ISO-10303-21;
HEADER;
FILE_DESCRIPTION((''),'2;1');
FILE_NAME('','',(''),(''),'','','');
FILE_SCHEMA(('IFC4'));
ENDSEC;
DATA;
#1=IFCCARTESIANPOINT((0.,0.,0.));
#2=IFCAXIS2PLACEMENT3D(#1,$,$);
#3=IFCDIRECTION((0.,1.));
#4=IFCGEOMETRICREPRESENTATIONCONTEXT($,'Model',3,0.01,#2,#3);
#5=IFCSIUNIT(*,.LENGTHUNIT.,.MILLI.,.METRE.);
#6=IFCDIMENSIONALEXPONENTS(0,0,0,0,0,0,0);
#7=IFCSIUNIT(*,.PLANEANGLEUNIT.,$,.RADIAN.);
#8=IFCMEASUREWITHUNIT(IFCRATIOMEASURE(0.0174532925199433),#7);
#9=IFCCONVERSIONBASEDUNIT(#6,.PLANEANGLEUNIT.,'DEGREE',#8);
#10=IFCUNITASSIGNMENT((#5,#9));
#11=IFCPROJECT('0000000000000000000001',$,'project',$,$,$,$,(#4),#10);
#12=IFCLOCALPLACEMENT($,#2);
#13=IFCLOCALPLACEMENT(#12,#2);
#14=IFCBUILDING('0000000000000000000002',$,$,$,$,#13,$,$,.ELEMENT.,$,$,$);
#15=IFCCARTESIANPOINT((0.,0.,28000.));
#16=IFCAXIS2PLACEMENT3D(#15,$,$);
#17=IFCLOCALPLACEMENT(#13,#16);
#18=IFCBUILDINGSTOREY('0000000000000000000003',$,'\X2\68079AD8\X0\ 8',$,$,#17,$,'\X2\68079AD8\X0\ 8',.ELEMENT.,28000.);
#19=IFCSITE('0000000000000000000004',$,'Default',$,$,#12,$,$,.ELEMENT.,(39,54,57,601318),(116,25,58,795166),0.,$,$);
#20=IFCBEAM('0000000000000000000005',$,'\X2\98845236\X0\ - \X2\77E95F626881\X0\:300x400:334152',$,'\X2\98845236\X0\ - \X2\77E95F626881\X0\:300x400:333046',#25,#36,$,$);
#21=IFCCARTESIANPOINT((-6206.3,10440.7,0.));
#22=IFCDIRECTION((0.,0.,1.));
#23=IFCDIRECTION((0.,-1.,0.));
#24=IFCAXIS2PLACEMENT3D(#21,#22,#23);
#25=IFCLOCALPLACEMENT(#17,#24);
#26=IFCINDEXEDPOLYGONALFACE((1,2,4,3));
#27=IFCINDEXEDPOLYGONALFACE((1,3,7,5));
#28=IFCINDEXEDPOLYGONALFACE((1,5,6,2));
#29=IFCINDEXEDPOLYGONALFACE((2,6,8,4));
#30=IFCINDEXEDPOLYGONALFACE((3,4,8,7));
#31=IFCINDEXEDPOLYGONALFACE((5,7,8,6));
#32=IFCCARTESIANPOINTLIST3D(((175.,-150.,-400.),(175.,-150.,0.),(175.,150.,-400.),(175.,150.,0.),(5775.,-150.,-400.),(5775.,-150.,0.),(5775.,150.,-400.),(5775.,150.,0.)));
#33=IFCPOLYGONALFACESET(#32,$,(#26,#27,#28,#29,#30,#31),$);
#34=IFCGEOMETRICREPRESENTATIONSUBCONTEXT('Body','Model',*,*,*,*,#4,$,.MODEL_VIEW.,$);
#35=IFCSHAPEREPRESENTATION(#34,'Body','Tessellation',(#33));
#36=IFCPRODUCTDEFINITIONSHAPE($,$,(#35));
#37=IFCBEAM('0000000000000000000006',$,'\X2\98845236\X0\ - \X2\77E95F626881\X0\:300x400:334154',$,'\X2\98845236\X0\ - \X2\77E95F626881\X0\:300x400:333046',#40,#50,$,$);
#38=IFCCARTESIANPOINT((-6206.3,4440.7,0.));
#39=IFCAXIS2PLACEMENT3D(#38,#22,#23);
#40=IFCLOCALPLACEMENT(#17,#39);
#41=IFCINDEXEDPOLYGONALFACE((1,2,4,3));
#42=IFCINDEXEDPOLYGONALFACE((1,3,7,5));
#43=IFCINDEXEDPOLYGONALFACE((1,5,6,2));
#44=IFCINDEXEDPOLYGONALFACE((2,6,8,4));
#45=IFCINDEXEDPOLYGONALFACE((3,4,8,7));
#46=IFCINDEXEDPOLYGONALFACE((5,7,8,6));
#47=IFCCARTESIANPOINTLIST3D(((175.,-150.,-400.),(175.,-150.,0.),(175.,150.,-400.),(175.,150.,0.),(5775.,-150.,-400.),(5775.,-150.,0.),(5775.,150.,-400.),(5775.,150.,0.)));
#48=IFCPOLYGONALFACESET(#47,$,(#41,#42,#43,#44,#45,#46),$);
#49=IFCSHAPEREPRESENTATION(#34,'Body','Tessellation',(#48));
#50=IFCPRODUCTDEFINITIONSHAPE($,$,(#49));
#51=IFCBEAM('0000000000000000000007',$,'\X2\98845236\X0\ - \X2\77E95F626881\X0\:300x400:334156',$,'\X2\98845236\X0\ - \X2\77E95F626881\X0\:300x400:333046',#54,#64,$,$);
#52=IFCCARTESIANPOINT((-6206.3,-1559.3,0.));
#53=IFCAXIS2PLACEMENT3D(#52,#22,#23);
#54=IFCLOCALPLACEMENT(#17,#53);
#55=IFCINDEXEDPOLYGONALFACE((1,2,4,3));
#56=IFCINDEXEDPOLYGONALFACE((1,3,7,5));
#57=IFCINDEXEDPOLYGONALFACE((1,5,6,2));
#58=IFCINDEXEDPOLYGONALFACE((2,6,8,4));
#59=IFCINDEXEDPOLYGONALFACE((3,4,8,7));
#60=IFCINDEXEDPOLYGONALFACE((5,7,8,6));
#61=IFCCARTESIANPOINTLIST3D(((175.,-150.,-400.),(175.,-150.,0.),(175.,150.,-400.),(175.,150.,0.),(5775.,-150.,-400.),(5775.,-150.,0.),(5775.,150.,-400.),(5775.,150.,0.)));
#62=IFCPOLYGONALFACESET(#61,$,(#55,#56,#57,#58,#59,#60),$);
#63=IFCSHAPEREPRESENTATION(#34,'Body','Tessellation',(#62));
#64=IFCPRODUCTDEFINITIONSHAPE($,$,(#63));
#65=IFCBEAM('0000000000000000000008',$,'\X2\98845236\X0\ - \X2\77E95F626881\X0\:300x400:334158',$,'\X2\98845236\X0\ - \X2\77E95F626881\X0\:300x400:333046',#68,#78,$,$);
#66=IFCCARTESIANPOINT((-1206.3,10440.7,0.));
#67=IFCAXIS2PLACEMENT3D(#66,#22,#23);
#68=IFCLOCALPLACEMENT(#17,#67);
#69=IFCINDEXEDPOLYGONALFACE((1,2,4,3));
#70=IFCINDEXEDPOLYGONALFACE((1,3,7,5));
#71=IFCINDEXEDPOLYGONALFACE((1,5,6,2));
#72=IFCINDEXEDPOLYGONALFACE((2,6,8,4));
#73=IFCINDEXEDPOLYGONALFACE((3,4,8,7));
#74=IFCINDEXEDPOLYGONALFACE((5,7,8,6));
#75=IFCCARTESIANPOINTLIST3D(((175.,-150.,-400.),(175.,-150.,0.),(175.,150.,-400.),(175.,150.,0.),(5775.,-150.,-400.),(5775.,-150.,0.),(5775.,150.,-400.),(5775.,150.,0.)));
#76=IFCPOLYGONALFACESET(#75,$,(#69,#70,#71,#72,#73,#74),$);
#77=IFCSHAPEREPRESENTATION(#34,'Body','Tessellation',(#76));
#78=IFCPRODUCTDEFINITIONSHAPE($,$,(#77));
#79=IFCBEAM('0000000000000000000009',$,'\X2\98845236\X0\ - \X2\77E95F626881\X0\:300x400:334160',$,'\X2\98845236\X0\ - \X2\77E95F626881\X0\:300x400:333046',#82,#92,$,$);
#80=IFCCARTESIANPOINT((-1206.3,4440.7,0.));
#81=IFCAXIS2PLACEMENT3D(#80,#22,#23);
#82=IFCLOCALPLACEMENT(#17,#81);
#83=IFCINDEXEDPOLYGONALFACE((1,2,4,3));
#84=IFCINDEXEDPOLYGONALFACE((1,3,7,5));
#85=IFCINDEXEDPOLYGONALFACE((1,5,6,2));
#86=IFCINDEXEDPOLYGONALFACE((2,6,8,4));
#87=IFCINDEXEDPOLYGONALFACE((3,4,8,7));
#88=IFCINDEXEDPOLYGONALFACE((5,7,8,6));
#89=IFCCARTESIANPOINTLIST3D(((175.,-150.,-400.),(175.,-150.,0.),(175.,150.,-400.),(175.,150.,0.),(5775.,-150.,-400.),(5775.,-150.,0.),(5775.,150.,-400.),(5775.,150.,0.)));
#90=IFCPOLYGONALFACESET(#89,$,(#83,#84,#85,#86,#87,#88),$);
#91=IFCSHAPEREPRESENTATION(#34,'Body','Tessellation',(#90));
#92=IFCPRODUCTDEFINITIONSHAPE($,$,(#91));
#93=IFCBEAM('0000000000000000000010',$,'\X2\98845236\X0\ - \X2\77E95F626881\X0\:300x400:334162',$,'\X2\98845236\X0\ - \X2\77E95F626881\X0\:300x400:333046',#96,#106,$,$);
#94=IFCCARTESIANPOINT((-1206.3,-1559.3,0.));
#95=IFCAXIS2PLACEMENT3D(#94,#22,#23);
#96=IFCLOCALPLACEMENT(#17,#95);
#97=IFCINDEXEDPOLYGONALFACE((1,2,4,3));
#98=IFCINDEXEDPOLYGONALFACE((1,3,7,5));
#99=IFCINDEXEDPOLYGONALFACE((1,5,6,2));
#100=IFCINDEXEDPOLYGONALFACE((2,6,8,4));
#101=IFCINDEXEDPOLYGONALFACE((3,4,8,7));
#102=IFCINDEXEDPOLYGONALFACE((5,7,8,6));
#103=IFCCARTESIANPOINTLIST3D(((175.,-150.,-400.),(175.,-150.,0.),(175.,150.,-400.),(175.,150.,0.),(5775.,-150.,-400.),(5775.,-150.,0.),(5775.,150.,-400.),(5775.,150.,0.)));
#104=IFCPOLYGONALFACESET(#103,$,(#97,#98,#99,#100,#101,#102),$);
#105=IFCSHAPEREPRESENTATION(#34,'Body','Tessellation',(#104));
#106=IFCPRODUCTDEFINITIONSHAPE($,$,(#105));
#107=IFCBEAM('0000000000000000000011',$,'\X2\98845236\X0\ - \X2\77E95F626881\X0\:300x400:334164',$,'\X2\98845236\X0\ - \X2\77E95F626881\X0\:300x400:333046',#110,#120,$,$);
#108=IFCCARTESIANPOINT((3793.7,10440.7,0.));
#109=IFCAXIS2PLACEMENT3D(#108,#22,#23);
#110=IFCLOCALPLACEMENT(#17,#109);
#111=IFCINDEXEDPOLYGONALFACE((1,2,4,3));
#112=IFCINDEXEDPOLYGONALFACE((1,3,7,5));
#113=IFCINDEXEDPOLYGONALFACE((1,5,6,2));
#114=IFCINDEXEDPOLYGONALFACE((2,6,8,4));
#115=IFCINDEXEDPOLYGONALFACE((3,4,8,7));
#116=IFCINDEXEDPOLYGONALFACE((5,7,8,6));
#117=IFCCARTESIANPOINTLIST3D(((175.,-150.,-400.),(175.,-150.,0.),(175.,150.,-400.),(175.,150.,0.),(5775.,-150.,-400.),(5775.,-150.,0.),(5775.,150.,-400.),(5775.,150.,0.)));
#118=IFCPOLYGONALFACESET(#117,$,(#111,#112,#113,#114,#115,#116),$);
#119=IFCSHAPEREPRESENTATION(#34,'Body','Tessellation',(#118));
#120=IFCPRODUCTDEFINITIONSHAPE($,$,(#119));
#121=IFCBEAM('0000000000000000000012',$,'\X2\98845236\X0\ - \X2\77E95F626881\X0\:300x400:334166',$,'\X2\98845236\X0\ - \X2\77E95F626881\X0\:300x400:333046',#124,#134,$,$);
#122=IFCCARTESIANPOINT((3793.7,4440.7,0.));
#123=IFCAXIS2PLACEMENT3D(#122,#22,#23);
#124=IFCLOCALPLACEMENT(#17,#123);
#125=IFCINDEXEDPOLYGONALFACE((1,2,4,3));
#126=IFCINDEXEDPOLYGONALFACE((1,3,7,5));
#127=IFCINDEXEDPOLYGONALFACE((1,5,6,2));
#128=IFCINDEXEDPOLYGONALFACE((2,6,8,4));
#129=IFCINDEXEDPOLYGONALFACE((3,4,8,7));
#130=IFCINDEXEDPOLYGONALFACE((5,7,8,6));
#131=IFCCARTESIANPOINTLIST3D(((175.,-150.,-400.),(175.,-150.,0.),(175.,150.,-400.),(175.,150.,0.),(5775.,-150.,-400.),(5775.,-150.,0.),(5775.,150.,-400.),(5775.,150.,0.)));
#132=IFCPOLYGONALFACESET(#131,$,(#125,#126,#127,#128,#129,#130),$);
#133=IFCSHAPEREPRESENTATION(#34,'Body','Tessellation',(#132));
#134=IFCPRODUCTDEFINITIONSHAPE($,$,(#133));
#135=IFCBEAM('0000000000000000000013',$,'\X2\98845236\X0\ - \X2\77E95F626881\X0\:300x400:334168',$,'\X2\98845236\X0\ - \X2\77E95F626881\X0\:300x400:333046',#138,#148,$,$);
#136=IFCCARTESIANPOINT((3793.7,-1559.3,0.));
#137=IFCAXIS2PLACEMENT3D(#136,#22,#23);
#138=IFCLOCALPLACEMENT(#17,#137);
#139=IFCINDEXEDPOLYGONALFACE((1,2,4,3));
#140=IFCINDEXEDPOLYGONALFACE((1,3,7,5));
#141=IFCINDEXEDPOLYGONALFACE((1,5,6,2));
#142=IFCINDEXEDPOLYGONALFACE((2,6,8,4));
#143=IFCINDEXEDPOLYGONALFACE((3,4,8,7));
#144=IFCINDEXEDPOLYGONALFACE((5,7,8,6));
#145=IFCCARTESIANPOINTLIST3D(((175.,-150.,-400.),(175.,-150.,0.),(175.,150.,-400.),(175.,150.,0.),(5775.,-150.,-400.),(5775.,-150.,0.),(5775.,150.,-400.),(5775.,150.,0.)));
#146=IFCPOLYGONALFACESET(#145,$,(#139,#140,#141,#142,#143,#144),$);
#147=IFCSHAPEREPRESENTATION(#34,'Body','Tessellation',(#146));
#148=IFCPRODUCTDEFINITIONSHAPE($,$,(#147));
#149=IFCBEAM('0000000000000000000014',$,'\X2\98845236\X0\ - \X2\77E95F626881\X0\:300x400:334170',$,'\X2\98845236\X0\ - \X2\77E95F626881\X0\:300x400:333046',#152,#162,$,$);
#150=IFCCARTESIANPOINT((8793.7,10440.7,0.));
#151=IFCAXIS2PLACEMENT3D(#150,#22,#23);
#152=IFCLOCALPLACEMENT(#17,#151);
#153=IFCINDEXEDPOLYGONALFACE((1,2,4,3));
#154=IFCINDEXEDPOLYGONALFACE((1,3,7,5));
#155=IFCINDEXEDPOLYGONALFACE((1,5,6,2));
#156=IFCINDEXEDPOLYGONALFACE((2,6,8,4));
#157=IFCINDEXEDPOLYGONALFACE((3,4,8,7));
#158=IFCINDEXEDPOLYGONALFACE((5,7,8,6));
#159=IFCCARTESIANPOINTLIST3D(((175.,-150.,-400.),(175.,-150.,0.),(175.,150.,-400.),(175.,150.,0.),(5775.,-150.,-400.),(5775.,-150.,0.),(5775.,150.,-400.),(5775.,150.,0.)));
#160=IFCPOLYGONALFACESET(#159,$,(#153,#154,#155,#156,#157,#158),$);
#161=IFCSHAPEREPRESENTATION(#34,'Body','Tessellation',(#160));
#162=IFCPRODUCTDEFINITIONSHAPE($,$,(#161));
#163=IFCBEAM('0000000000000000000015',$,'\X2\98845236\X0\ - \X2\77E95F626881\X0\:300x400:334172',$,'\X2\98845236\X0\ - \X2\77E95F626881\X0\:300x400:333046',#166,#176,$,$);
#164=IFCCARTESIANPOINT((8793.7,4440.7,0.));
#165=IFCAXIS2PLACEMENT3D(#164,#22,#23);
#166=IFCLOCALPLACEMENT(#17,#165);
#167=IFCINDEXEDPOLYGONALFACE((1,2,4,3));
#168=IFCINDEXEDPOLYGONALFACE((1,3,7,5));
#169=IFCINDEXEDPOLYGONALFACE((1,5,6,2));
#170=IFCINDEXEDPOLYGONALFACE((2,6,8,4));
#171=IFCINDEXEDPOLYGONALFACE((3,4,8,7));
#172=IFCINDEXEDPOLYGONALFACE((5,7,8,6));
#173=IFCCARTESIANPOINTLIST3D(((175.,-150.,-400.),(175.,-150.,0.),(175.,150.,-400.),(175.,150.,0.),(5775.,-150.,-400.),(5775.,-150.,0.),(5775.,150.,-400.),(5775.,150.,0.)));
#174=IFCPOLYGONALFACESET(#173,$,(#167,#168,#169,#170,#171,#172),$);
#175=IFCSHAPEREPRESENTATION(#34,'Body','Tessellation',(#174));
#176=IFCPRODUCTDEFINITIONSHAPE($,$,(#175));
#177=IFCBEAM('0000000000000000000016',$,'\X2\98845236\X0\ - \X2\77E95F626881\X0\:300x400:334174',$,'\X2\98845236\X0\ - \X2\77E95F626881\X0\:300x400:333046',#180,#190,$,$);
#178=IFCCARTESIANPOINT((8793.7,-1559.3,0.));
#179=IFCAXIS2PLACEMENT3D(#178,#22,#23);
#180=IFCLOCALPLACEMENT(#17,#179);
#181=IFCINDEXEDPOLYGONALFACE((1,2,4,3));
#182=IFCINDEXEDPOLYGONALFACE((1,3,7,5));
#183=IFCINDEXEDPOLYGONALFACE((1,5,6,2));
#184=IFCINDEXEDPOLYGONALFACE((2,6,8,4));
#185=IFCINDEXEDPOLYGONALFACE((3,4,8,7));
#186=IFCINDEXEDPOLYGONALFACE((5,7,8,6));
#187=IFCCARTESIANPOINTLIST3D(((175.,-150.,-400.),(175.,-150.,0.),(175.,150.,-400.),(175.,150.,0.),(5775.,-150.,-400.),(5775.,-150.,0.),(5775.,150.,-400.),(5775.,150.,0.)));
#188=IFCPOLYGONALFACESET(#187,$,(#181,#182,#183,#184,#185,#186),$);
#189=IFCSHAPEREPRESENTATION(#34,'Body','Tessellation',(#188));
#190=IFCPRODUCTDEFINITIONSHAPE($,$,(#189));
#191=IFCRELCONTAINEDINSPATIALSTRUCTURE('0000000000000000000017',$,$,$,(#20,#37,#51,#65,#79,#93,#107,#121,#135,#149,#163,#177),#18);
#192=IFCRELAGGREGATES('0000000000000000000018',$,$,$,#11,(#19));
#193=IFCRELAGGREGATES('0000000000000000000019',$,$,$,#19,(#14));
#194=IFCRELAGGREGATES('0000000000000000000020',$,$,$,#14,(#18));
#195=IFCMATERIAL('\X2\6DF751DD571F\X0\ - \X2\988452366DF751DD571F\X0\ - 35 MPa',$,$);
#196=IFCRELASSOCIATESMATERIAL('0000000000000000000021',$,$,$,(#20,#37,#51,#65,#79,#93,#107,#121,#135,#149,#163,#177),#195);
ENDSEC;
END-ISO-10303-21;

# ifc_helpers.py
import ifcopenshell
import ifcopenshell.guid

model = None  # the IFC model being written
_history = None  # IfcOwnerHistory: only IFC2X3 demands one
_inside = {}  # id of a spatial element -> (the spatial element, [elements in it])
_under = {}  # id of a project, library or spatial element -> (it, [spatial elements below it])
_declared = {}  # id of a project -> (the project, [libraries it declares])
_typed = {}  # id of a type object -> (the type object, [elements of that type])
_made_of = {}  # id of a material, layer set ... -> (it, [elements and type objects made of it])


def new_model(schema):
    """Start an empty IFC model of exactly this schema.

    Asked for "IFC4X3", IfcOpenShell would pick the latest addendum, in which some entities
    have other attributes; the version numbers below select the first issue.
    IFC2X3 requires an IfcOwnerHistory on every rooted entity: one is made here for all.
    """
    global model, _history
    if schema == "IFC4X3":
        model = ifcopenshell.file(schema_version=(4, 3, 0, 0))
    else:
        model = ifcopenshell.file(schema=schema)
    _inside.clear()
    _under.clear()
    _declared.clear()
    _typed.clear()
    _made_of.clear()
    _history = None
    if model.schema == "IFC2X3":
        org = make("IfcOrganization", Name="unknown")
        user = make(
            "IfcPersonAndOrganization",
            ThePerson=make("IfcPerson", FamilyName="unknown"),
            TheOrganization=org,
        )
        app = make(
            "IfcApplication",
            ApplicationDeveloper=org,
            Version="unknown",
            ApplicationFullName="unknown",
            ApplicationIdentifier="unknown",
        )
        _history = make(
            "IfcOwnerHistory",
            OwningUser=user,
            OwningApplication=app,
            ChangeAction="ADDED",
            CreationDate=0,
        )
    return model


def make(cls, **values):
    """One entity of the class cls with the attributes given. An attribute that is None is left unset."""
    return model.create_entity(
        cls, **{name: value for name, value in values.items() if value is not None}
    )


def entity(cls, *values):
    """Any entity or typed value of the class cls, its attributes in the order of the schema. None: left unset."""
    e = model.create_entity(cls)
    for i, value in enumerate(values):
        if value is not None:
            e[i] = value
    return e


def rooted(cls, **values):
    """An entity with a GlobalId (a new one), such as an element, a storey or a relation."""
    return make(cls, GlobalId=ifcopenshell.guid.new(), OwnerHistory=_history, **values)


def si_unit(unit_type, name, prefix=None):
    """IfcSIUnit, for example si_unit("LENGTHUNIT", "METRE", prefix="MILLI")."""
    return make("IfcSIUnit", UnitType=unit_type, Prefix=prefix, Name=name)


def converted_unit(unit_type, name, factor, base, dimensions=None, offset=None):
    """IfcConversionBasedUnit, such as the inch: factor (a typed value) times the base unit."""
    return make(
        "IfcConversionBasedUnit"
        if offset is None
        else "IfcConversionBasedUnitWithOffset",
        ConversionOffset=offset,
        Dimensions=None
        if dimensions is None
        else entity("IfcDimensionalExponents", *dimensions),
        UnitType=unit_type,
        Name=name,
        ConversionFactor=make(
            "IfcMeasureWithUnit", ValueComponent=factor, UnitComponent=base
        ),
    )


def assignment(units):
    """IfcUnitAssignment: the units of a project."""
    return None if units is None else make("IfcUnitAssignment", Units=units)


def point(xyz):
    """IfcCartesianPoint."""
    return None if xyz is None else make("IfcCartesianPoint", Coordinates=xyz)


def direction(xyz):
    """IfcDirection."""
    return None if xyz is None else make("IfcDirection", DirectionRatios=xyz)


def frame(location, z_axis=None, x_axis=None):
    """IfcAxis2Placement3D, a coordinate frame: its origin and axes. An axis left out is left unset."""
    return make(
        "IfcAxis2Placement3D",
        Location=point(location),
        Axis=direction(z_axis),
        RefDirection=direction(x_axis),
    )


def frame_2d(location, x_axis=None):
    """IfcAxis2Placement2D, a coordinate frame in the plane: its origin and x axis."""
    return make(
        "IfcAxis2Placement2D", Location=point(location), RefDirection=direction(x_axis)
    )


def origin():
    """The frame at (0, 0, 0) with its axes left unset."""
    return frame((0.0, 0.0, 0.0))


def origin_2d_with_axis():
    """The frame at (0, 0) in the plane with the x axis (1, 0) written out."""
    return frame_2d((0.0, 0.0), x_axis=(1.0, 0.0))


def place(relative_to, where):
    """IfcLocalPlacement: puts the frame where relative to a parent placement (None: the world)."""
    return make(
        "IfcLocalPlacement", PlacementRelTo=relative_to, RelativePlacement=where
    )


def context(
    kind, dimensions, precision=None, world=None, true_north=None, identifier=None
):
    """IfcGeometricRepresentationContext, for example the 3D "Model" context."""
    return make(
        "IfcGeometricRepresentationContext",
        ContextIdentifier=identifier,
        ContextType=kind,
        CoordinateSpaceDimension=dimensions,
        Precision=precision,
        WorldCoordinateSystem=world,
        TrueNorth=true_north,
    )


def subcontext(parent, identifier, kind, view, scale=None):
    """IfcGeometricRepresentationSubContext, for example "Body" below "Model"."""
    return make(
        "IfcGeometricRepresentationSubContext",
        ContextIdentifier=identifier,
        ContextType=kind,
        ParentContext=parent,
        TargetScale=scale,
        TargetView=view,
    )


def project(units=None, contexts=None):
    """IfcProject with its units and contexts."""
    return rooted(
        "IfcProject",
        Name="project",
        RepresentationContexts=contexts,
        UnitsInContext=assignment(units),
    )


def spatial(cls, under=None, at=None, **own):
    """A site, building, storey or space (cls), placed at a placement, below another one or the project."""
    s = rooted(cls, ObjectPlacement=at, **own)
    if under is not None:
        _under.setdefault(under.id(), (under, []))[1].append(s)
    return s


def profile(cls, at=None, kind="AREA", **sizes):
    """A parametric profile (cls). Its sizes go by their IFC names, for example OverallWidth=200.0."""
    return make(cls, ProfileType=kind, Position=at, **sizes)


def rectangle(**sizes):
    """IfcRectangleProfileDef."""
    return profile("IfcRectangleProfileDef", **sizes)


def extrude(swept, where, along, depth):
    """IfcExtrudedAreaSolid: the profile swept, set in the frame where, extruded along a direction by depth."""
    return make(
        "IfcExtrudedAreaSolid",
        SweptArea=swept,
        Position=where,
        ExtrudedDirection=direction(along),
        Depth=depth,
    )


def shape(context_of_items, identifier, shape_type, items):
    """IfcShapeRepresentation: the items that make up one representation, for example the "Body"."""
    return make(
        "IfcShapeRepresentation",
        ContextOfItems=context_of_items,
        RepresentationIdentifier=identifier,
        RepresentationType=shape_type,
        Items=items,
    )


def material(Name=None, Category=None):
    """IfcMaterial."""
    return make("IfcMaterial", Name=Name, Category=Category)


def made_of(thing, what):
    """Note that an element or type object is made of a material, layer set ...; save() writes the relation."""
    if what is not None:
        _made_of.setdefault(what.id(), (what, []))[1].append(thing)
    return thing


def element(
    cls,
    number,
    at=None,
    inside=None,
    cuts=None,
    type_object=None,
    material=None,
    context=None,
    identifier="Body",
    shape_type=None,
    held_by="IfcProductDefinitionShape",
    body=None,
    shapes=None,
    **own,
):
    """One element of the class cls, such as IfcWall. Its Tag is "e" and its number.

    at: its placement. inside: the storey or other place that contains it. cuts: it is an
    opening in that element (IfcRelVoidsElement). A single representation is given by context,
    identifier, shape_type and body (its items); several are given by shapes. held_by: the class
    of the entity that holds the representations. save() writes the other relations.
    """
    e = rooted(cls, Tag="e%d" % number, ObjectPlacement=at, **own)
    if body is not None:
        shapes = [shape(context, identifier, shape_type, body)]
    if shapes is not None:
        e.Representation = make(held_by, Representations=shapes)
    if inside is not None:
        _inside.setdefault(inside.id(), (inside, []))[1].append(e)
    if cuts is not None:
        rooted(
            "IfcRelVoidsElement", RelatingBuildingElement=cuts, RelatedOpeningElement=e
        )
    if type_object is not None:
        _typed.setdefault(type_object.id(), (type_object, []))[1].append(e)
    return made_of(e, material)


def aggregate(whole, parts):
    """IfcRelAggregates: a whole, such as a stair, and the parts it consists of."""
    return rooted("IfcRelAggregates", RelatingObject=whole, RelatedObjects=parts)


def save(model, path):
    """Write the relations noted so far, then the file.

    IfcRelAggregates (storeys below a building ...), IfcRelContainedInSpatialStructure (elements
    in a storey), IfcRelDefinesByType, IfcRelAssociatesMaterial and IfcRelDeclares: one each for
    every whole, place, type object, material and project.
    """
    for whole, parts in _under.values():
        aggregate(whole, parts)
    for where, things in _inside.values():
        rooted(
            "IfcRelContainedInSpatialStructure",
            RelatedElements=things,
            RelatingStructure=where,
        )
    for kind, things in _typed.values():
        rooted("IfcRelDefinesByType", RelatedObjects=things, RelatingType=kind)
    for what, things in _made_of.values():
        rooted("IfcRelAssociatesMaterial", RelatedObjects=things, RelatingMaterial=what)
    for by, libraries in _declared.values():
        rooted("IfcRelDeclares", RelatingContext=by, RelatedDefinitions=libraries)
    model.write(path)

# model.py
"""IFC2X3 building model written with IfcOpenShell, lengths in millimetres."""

from ifc_helpers import new_model, entity, si_unit, converted_unit, direction, frame, frame_2d, origin, origin_2d_with_axis, place, context, subcontext, project, spatial, rectangle, extrude, material, element, save


model = new_model("IFC2X3")

# Units and contexts
model_context = context("Model", 3, precision=0.01, world=origin(), true_north=direction((0.0, 1.0)))
body_context = subcontext(model_context, "Body", "Model", "MODEL_VIEW")
ifc_project = project(units=[si_unit("LENGTHUNIT", "METRE", prefix="MILLI"), converted_unit("PLANEANGLEUNIT", "DEGREE", entity("IfcRatioMeasure", 0.0174532925199433), si_unit("PLANEANGLEUNIT", "RADIAN"), dimensions=[0, 0, 0, 0, 0, 0, 0])], contexts=[model_context])

# Site, building, storey
site_placement = place(None, origin())
site = spatial("IfcSite", under=ifc_project, at=site_placement, Name="Default", CompositionType="ELEMENT", RefLatitude=(39, 54, 57, 601318), RefLongitude=(116, 25, 58, 795166), RefElevation=0.0)
building_placement = place(site_placement, origin())
building = spatial("IfcBuilding", under=site, at=building_placement, CompositionType="ELEMENT")
storey_placement = place(building_placement, frame((0.0, 0.0, 28000.0)))
storey = spatial("IfcBuildingStorey", under=building, at=storey_placement, Name="标高 8", LongName="标高 8", CompositionType="ELEMENT", Elevation=28000.0)

# Beams
ifc_material_1 = material(Name="混凝土 - 预制混凝土 - 35 MPa")
for number, where, z_axis, x_axis, name in (
    (1, (-6206.3, 10440.7, 0.0), (0.0, 0.0, 1.0), (0.0, -1.0, 0.0), "预制 - 矩形梁:300x400:334152"),
    (2, (-6206.3, 4440.7, 0.0), (0.0, 0.0, 1.0), (0.0, -1.0, 0.0), "预制 - 矩形梁:300x400:334154"),
    (3, (-6206.3, -1559.3, 0.0), (0.0, 0.0, 1.0), (0.0, -1.0, 0.0), "预制 - 矩形梁:300x400:334156"),
):
    element("IfcBeam", number, at=place(storey_placement, frame(where, z_axis=z_axis, x_axis=x_axis)), inside=storey, material=ifc_material_1, Name=name, ObjectType="预制 - 矩形梁:300x400:333046", context=body_context, shape_type="SweptSolid", body=[
        extrude(rectangle(XDim=400.0, YDim=300.0, at=origin_2d_with_axis()), frame((175.0, 0.0, -200.0), z_axis=(1.0, 0.0, 0.0), x_axis=(0.0, 0.0, -1.0)), (0.0, 0.0, 1.0), 5600.0),
    ])
beam_1_placement = place(storey_placement, frame((-1206.3, 10440.7, 0.0), z_axis=(0.0, 0.0, 1.0), x_axis=(0.0, -1.0, 0.0)))
element("IfcBeam", 4, at=beam_1_placement, inside=storey, material=ifc_material_1, Name="预制 - 矩形梁:300x400:334158", ObjectType="预制 - 矩形梁:300x400:333046", context=body_context, shape_type="SweptSolid", body=[
    extrude(rectangle(XDim=400.0, YDim=300.0, at=frame_2d((0.0, 0.0), x_axis=(1.0, 0.0))), frame((175.0, 0.0, -200.0), z_axis=(1.0, 0.0, 0.0), x_axis=(0.0, 0.0, -1.0)), (0.0, 0.0, 1.0), 5600.0),
])
beam_2_placement = place(storey_placement, frame((-1206.3, 4440.7, 0.0), z_axis=(0.0, 0.0, 1.0), x_axis=(0.0, -1.0, 0.0)))
element("IfcBeam", 5, at=beam_2_placement, inside=storey, material=ifc_material_1, Name="预制 - 矩形梁:300x400:334160", ObjectType="预制 - 矩形梁:300x400:333046", context=body_context, shape_type="SweptSolid", body=[
    extrude(rectangle(XDim=400.0, YDim=300.0, at=frame_2d((0.0, 0.0), x_axis=(1.0, 0.0))), frame((175.0, 0.0, -200.0), z_axis=(1.0, 0.0, 0.0), x_axis=(0.0, 0.0, -1.0)), (0.0, 0.0, 1.0), 5600.0),
])
beam_3_placement = place(storey_placement, frame((-1206.3, -1559.3, 0.0), z_axis=(0.0, 0.0, 1.0), x_axis=(0.0, -1.0, 0.0)))
element("IfcBeam", 6, at=beam_3_placement, inside=storey, material=ifc_material_1, Name="预制 - 矩形梁:300x400:334162", ObjectType="预制 - 矩形梁:300x400:333046", context=body_context, shape_type="SweptSolid", body=[
    extrude(rectangle(XDim=400.0, YDim=300.0, at=frame_2d((0.0, 0.0), x_axis=(1.0, 0.0))), frame((175.0, 0.0, -200.0), z_axis=(1.0, 0.0, 0.0), x_axis=(0.0, 0.0, -1.0)), (0.0, 0.0, 1.0), 5600.0),
])
beam_4_placement = place(storey_placement, frame((3793.7, 10440.7, 0.0), z_axis=(0.0, 0.0, 1.0), x_axis=(0.0, -1.0, 0.0)))
element("IfcBeam", 7, at=beam_4_placement, inside=storey, material=ifc_material_1, Name="预制 - 矩形梁:300x400:334164", ObjectType="预制 - 矩形梁:300x400:333046", context=body_context, shape_type="SweptSolid", body=[
    extrude(rectangle(XDim=400.0, YDim=300.0, at=frame_2d((0.0, 0.0), x_axis=(1.0, 0.0))), frame((175.0, 0.0, -200.0), z_axis=(1.0, 0.0, 0.0), x_axis=(0.0, 0.0, -1.0)), (0.0, 0.0, 1.0), 5600.0),
])
beam_5_placement = place(storey_placement, frame((3793.7, 4440.7, 0.0), z_axis=(0.0, 0.0, 1.0), x_axis=(0.0, -1.0, 0.0)))
element("IfcBeam", 8, at=beam_5_placement, inside=storey, material=ifc_material_1, Name="预制 - 矩形梁:300x400:334166", ObjectType="预制 - 矩形梁:300x400:333046", context=body_context, shape_type="SweptSolid", body=[
    extrude(rectangle(XDim=400.0, YDim=300.0, at=origin_2d_with_axis()), frame((175.0, 0.0, -200.0), z_axis=(1.0, 0.0, 0.0), x_axis=(0.0, 0.0, -1.0)), (0.0, 0.0, 1.0), 5600.0),
])
beam_6_placement = place(storey_placement, frame((3793.7, -1559.3, 0.0), z_axis=(0.0, 0.0, 1.0), x_axis=(0.0, -1.0, 0.0)))
element("IfcBeam", 9, at=beam_6_placement, inside=storey, material=ifc_material_1, Name="预制 - 矩形梁:300x400:334168", ObjectType="预制 - 矩形梁:300x400:333046", context=body_context, shape_type="SweptSolid", body=[
    extrude(rectangle(XDim=400.0, YDim=300.0, at=frame_2d((0.0, 0.0), x_axis=(1.0, 0.0))), frame((175.0, 0.0, -200.0), z_axis=(1.0, 0.0, 0.0), x_axis=(0.0, 0.0, -1.0)), (0.0, 0.0, 1.0), 5600.0),
])
for number, where, z_axis, x_axis, name in (
    (10, (8793.7, 10440.7, 0.0), (0.0, 0.0, 1.0), (0.0, -1.0, 0.0), "预制 - 矩形梁:300x400:334170"),
    (11, (8793.7, 4440.7, 0.0), (0.0, 0.0, 1.0), (0.0, -1.0, 0.0), "预制 - 矩形梁:300x400:334172"),
    (12, (8793.7, -1559.3, 0.0), (0.0, 0.0, 1.0), (0.0, -1.0, 0.0), "预制 - 矩形梁:300x400:334174"),
):
    element("IfcBeam", number, at=place(storey_placement, frame(where, z_axis=z_axis, x_axis=x_axis)), inside=storey, material=ifc_material_1, Name=name, ObjectType="预制 - 矩形梁:300x400:333046", context=body_context, shape_type="SweptSolid", body=[
        extrude(rectangle(XDim=400.0, YDim=300.0, at=origin_2d_with_axis()), frame((175.0, 0.0, -200.0), z_axis=(1.0, 0.0, 0.0), x_axis=(0.0, 0.0, -1.0)), (0.0, 0.0, 1.0), 5600.0),
    ])

save(model, "model.ifc")
